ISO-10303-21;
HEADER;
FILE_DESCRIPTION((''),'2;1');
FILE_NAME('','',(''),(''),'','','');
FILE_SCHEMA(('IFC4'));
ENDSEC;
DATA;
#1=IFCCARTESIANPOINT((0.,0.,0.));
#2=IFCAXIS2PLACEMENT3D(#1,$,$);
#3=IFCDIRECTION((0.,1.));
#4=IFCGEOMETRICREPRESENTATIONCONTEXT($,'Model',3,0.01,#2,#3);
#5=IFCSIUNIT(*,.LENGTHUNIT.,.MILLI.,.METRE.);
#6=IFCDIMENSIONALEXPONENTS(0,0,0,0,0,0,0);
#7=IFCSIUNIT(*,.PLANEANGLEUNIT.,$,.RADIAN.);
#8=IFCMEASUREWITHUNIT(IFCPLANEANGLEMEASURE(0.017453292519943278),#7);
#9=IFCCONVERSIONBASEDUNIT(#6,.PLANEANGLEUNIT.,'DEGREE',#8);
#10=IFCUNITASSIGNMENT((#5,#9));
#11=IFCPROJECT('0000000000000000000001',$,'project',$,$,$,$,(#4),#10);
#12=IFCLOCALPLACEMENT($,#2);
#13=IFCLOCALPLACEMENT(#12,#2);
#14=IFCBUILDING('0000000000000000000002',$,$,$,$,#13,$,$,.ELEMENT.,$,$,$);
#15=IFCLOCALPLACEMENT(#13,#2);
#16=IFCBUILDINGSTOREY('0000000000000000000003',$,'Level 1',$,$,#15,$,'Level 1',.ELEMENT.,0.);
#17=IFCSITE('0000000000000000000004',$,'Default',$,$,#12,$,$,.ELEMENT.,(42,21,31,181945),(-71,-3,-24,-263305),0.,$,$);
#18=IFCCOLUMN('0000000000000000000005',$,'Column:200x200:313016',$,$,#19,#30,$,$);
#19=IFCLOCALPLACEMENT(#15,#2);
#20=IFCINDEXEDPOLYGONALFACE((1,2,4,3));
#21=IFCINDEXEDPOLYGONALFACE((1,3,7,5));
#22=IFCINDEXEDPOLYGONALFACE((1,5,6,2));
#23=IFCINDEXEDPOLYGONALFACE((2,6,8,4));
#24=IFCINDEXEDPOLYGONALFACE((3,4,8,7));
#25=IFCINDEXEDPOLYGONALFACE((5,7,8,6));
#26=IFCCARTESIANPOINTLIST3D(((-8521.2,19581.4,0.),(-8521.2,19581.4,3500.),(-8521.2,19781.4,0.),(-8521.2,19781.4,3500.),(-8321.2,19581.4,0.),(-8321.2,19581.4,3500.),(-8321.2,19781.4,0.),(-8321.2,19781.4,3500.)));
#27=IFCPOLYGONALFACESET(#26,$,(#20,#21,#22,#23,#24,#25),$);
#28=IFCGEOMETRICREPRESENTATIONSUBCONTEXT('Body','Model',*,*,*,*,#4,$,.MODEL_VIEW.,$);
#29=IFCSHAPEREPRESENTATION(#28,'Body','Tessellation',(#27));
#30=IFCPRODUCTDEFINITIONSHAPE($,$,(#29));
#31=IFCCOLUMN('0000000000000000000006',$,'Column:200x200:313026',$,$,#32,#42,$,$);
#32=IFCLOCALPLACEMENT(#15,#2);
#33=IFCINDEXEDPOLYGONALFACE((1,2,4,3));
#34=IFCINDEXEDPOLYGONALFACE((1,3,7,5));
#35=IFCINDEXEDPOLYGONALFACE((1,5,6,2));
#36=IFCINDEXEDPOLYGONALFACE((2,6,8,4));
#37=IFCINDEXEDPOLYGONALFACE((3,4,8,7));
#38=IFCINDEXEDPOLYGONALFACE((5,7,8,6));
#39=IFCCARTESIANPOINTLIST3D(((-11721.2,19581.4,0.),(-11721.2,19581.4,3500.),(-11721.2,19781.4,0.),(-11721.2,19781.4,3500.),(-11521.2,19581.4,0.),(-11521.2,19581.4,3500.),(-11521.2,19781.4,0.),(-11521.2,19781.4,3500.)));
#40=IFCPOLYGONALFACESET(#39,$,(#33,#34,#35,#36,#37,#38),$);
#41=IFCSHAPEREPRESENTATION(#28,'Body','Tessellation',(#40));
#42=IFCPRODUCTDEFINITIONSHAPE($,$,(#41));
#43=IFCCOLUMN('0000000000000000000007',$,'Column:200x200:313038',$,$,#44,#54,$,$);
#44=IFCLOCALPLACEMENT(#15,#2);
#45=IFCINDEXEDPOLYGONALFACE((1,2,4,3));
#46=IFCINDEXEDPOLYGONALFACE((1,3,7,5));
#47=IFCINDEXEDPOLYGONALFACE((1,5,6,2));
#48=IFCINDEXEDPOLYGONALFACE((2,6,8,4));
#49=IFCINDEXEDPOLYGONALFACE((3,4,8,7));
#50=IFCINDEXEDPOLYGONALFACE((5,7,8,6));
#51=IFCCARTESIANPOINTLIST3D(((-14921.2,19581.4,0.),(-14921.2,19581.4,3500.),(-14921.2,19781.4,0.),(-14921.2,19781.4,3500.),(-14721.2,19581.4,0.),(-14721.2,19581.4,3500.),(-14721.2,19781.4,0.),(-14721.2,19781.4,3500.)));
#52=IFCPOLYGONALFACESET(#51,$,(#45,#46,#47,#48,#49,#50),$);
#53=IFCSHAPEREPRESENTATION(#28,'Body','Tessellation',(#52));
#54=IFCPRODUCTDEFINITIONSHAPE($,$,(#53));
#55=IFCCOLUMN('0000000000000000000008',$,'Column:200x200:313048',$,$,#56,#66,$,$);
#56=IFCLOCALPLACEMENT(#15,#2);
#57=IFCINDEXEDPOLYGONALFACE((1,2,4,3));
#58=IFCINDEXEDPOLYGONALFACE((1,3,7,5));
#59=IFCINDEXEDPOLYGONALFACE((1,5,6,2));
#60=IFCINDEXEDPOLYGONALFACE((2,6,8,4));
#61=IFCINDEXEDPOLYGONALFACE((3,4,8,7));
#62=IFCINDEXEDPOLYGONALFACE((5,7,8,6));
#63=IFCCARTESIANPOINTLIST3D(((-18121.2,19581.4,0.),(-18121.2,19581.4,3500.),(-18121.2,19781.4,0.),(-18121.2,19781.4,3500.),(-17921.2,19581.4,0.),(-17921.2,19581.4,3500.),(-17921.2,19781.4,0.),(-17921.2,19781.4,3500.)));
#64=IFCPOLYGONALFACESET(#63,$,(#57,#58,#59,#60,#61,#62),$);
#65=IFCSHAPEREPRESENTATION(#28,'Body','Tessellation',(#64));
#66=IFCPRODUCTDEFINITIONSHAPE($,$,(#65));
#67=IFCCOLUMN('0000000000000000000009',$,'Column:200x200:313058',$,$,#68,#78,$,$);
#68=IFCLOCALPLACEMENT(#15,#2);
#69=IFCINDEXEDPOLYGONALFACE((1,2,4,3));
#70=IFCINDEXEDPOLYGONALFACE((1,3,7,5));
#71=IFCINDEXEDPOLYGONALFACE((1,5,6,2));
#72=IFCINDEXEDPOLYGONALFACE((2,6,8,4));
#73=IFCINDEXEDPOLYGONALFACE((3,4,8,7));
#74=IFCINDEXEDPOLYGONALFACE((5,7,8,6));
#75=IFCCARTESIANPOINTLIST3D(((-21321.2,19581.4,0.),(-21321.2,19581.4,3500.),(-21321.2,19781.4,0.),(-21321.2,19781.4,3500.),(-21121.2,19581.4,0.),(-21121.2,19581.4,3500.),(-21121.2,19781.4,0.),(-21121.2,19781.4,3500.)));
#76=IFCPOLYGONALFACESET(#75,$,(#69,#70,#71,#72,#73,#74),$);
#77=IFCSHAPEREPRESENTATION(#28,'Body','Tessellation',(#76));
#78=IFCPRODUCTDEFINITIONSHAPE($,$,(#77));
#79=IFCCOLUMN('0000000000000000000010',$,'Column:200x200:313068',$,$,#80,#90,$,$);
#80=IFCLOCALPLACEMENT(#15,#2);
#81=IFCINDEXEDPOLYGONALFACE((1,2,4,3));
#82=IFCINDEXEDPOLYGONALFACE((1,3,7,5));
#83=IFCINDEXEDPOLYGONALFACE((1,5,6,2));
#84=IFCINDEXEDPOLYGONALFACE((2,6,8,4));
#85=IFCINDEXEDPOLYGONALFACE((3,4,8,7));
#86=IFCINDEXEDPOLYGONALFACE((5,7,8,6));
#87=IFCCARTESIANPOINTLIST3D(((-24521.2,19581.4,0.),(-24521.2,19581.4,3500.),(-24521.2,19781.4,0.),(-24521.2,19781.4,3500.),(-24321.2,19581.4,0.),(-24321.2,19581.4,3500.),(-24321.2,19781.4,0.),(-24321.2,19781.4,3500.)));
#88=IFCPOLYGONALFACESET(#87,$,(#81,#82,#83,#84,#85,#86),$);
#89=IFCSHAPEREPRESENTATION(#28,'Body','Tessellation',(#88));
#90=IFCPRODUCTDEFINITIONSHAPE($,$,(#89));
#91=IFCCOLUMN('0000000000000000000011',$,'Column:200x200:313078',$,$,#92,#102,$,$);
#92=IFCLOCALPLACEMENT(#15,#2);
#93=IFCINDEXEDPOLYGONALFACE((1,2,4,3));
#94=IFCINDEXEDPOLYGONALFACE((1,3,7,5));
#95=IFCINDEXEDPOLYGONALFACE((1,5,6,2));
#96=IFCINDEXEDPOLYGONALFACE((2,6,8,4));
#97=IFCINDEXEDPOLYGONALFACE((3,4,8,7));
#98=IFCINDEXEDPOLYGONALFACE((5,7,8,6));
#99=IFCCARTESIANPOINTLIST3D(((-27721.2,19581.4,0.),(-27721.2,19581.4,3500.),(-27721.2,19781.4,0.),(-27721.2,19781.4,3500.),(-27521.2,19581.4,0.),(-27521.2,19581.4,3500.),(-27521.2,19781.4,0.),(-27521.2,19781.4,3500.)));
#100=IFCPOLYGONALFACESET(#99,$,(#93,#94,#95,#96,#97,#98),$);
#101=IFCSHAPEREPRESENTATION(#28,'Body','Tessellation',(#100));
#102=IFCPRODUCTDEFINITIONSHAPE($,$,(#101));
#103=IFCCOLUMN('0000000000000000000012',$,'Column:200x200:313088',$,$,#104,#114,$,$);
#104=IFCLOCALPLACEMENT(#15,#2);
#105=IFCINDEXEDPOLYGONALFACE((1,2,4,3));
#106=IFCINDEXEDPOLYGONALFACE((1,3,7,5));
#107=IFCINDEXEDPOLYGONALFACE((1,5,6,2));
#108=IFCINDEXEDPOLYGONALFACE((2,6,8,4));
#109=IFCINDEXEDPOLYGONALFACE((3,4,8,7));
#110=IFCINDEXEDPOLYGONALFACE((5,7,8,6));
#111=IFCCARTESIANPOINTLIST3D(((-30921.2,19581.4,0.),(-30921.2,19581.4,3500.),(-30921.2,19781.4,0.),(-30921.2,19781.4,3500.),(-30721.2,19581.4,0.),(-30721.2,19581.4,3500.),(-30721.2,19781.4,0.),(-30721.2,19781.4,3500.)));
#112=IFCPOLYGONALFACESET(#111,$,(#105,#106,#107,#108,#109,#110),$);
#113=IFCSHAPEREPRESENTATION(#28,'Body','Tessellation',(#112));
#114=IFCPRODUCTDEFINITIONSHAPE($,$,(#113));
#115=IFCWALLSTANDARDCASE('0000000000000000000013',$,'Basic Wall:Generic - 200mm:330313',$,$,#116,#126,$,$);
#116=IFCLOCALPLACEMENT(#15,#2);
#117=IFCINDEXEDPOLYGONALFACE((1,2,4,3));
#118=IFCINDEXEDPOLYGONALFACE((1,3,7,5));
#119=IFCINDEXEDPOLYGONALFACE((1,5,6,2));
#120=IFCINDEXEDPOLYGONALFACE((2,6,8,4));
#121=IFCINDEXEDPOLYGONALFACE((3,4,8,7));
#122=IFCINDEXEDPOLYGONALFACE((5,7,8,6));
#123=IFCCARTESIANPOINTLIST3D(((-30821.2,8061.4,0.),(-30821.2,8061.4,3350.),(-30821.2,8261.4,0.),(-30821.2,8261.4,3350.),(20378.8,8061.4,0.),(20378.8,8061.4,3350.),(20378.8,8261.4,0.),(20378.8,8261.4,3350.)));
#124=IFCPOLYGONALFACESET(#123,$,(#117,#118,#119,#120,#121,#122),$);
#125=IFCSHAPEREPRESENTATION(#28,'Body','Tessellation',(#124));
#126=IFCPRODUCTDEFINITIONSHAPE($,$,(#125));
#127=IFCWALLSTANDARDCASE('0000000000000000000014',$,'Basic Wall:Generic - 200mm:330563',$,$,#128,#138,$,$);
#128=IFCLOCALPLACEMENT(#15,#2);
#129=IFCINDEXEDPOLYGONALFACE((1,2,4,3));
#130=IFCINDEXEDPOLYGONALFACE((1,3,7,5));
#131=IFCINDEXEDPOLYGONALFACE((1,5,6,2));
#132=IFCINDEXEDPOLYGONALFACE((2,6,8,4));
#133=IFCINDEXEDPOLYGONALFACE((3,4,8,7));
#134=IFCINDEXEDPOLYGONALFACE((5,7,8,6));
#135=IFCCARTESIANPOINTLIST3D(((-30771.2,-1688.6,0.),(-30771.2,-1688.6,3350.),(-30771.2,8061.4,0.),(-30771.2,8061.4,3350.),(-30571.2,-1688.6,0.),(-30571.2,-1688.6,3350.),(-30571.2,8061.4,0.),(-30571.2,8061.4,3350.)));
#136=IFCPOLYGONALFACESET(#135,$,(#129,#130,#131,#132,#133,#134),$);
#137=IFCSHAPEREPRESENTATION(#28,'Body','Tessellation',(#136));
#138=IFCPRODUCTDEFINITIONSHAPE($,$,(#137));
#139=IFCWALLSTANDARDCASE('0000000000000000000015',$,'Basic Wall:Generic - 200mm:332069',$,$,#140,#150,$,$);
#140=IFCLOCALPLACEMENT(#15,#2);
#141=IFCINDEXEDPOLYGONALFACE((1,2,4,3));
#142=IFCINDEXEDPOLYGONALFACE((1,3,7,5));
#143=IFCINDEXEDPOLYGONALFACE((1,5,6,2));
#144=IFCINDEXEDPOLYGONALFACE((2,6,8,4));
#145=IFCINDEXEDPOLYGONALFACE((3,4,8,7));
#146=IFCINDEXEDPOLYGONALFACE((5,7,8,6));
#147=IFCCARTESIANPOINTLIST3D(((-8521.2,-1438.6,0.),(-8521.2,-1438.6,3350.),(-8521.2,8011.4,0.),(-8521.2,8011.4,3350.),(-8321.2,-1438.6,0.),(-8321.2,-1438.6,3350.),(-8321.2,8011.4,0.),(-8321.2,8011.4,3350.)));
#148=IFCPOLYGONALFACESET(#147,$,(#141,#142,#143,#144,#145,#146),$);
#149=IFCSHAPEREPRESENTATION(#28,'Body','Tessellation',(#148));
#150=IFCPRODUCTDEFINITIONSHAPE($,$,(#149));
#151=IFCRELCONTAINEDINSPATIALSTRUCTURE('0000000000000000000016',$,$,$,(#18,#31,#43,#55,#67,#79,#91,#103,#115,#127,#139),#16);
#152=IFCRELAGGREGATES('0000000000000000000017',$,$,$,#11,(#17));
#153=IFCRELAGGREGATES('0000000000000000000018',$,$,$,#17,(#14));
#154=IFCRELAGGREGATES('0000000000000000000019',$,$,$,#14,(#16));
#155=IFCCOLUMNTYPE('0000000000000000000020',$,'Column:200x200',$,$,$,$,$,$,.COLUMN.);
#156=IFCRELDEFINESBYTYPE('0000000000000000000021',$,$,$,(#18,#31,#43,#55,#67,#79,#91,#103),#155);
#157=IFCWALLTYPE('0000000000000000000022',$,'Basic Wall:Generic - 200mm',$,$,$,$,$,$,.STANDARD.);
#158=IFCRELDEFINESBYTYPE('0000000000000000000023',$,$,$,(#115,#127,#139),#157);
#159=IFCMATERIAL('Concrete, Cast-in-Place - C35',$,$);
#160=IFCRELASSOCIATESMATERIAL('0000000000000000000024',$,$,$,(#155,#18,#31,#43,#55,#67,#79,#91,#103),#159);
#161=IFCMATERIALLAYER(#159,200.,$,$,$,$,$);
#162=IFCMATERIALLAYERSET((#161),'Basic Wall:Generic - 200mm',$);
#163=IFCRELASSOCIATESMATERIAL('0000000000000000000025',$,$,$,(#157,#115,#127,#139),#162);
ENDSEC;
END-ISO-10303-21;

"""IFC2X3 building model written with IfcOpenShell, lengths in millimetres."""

from ifc_helpers import new_model, entity, si_unit, converted_unit, direction, frame, frame_2d, origin, place, context, subcontext, project, spatial, rectangle, extrude, source, transform, mapped, material, layer, layer_set, layer_usage, type_object, type_shapes, element, save


model = new_model("IFC2X3")

# Units and contexts
model_context = context("Model", 3, precision=0.01, world=origin(), true_north=direction((0.0, 1.0)))
body_context = subcontext(model_context, "Body", "Model", "MODEL_VIEW")
ifc_project = project(units=[si_unit("LENGTHUNIT", "METRE", prefix="MILLI"), converted_unit("PLANEANGLEUNIT", "DEGREE", entity("IfcPlaneAngleMeasure", 0.017453292519943278), si_unit("PLANEANGLEUNIT", "RADIAN"), dimensions=[0, 0, 0, 0, 0, 0, 0])], contexts=[model_context])

# Site, building, storey
site_placement = place(None, origin())
site = spatial("IfcSite", under=ifc_project, at=site_placement, Name="Default", CompositionType="ELEMENT", RefLatitude=(42, 21, 31, 181945), RefLongitude=(-71, -3, -24, -263305), RefElevation=0.0)
building_placement = place(site_placement, origin())
building = spatial("IfcBuilding", under=site, at=building_placement, CompositionType="ELEMENT")
storey_placement = place(building_placement, origin())
storey = spatial("IfcBuildingStorey", under=building, at=storey_placement, Name="Level 1", LongName="Level 1", CompositionType="ELEMENT", Elevation=0.0)

# Columns
ifc_material = material(Name="Concrete, Cast-in-Place - C35")
column_type_1 = type_object("IfcColumnType", Name="Column:200x200", PredefinedType="COLUMN", material=ifc_material)
shared_shape_1 = source(origin(), body_context, "Body", "SweptSolid", [
    extrude(rectangle(XDim=200.0, YDim=200.0, at=frame_2d((0.0, 0.0), x_axis=(1.0, 0.0))), frame((0.0, 0.0, 0.0), z_axis=(0.0, 0.0, 1.0), x_axis=(-1.0, 0.0, 0.0)), (0.0, 0.0, 1.0), 3500.0),
])
type_shapes(column_type_1, [shared_shape_1])
for number, where, name in (
    (1, (-8421.2, 19681.4, 0.0), "Column:200x200:313016"),
    (2, (-11621.2, 19681.4, 0.0), "Column:200x200:313026"),
    (3, (-14821.2, 19681.4, 0.0), "Column:200x200:313038"),
    (4, (-18021.2, 19681.4, 0.0), "Column:200x200:313048"),
    (5, (-21221.2, 19681.4, 0.0), "Column:200x200:313058"),
    (6, (-24421.2, 19681.4, 0.0), "Column:200x200:313068"),
    (7, (-27621.2, 19681.4, 0.0), "Column:200x200:313078"),
    (8, (-30821.2, 19681.4, 0.0), "Column:200x200:313088"),
):
    element("IfcColumn", number, at=place(storey_placement, frame(where)), inside=storey, type_object=column_type_1, material=ifc_material, Name=name, context=body_context, shape_type="MappedRepresentation", body=[
        mapped(shared_shape_1, transform((0.0, 0.0, 0.0), scale=1.0)),
    ])

# Walls
ifc_layer = layer(ifc_material, 200.0)
ifc_layer_set = layer_set([ifc_layer], Name="Basic Wall:Generic - 200mm")
ifc_layer_usage_1 = layer_usage(ifc_layer_set, "AXIS2", "NEGATIVE", 100.0)
wall_type = type_object("IfcWallType", Name="Basic Wall:Generic - 200mm", PredefinedType="STANDARD", material=ifc_layer_set)
wall_1_placement = place(storey_placement, frame((-30821.2, 8161.4, 0.0)))
element("IfcWallStandardCase", 9, at=wall_1_placement, inside=storey, type_object=wall_type, material=ifc_layer_usage_1, Name="Basic Wall:Generic - 200mm:330313", context=body_context, shape_type="SweptSolid", body=[
    extrude(rectangle(XDim=51200.0, YDim=200.0, at=frame_2d((25600.0, 0.0), x_axis=(-1.0, 0.0))), origin(), (0.0, 0.0, 1.0), 3350.0),
])
ifc_layer_usage_2 = layer_usage(ifc_layer_set, "AXIS2", "NEGATIVE", 100.0)
wall_2_placement = place(storey_placement, frame((-30671.2, 8061.4, 0.0), z_axis=(0.0, 0.0, 1.0), x_axis=(0.0, -1.0, 0.0)))
element("IfcWallStandardCase", 10, at=wall_2_placement, inside=storey, type_object=wall_type, material=ifc_layer_usage_2, Name="Basic Wall:Generic - 200mm:330563", context=body_context, shape_type="SweptSolid", body=[
    extrude(rectangle(XDim=9750.0, YDim=200.0, at=frame_2d((4875.0, 0.0), x_axis=(-1.0, 0.0))), origin(), (0.0, 0.0, 1.0), 3350.0),
])
ifc_layer_usage_3 = layer_usage(ifc_layer_set, "AXIS2", "NEGATIVE", 100.0)
wall_3_placement = place(storey_placement, frame((-8421.2, 8011.4, 0.0), z_axis=(0.0, 0.0, 1.0), x_axis=(0.0, -1.0, 0.0)))
element("IfcWallStandardCase", 11, at=wall_3_placement, inside=storey, type_object=wall_type, material=ifc_layer_usage_3, Name="Basic Wall:Generic - 200mm:332069", context=body_context, shape_type="SweptSolid", body=[
    extrude(rectangle(XDim=9450.0, YDim=200.0, at=frame_2d((4725.0, 0.0), x_axis=(-1.0, 0.0))), origin(), (0.0, 0.0, 1.0), 3350.0),
])

save(model, "model.ifc")
